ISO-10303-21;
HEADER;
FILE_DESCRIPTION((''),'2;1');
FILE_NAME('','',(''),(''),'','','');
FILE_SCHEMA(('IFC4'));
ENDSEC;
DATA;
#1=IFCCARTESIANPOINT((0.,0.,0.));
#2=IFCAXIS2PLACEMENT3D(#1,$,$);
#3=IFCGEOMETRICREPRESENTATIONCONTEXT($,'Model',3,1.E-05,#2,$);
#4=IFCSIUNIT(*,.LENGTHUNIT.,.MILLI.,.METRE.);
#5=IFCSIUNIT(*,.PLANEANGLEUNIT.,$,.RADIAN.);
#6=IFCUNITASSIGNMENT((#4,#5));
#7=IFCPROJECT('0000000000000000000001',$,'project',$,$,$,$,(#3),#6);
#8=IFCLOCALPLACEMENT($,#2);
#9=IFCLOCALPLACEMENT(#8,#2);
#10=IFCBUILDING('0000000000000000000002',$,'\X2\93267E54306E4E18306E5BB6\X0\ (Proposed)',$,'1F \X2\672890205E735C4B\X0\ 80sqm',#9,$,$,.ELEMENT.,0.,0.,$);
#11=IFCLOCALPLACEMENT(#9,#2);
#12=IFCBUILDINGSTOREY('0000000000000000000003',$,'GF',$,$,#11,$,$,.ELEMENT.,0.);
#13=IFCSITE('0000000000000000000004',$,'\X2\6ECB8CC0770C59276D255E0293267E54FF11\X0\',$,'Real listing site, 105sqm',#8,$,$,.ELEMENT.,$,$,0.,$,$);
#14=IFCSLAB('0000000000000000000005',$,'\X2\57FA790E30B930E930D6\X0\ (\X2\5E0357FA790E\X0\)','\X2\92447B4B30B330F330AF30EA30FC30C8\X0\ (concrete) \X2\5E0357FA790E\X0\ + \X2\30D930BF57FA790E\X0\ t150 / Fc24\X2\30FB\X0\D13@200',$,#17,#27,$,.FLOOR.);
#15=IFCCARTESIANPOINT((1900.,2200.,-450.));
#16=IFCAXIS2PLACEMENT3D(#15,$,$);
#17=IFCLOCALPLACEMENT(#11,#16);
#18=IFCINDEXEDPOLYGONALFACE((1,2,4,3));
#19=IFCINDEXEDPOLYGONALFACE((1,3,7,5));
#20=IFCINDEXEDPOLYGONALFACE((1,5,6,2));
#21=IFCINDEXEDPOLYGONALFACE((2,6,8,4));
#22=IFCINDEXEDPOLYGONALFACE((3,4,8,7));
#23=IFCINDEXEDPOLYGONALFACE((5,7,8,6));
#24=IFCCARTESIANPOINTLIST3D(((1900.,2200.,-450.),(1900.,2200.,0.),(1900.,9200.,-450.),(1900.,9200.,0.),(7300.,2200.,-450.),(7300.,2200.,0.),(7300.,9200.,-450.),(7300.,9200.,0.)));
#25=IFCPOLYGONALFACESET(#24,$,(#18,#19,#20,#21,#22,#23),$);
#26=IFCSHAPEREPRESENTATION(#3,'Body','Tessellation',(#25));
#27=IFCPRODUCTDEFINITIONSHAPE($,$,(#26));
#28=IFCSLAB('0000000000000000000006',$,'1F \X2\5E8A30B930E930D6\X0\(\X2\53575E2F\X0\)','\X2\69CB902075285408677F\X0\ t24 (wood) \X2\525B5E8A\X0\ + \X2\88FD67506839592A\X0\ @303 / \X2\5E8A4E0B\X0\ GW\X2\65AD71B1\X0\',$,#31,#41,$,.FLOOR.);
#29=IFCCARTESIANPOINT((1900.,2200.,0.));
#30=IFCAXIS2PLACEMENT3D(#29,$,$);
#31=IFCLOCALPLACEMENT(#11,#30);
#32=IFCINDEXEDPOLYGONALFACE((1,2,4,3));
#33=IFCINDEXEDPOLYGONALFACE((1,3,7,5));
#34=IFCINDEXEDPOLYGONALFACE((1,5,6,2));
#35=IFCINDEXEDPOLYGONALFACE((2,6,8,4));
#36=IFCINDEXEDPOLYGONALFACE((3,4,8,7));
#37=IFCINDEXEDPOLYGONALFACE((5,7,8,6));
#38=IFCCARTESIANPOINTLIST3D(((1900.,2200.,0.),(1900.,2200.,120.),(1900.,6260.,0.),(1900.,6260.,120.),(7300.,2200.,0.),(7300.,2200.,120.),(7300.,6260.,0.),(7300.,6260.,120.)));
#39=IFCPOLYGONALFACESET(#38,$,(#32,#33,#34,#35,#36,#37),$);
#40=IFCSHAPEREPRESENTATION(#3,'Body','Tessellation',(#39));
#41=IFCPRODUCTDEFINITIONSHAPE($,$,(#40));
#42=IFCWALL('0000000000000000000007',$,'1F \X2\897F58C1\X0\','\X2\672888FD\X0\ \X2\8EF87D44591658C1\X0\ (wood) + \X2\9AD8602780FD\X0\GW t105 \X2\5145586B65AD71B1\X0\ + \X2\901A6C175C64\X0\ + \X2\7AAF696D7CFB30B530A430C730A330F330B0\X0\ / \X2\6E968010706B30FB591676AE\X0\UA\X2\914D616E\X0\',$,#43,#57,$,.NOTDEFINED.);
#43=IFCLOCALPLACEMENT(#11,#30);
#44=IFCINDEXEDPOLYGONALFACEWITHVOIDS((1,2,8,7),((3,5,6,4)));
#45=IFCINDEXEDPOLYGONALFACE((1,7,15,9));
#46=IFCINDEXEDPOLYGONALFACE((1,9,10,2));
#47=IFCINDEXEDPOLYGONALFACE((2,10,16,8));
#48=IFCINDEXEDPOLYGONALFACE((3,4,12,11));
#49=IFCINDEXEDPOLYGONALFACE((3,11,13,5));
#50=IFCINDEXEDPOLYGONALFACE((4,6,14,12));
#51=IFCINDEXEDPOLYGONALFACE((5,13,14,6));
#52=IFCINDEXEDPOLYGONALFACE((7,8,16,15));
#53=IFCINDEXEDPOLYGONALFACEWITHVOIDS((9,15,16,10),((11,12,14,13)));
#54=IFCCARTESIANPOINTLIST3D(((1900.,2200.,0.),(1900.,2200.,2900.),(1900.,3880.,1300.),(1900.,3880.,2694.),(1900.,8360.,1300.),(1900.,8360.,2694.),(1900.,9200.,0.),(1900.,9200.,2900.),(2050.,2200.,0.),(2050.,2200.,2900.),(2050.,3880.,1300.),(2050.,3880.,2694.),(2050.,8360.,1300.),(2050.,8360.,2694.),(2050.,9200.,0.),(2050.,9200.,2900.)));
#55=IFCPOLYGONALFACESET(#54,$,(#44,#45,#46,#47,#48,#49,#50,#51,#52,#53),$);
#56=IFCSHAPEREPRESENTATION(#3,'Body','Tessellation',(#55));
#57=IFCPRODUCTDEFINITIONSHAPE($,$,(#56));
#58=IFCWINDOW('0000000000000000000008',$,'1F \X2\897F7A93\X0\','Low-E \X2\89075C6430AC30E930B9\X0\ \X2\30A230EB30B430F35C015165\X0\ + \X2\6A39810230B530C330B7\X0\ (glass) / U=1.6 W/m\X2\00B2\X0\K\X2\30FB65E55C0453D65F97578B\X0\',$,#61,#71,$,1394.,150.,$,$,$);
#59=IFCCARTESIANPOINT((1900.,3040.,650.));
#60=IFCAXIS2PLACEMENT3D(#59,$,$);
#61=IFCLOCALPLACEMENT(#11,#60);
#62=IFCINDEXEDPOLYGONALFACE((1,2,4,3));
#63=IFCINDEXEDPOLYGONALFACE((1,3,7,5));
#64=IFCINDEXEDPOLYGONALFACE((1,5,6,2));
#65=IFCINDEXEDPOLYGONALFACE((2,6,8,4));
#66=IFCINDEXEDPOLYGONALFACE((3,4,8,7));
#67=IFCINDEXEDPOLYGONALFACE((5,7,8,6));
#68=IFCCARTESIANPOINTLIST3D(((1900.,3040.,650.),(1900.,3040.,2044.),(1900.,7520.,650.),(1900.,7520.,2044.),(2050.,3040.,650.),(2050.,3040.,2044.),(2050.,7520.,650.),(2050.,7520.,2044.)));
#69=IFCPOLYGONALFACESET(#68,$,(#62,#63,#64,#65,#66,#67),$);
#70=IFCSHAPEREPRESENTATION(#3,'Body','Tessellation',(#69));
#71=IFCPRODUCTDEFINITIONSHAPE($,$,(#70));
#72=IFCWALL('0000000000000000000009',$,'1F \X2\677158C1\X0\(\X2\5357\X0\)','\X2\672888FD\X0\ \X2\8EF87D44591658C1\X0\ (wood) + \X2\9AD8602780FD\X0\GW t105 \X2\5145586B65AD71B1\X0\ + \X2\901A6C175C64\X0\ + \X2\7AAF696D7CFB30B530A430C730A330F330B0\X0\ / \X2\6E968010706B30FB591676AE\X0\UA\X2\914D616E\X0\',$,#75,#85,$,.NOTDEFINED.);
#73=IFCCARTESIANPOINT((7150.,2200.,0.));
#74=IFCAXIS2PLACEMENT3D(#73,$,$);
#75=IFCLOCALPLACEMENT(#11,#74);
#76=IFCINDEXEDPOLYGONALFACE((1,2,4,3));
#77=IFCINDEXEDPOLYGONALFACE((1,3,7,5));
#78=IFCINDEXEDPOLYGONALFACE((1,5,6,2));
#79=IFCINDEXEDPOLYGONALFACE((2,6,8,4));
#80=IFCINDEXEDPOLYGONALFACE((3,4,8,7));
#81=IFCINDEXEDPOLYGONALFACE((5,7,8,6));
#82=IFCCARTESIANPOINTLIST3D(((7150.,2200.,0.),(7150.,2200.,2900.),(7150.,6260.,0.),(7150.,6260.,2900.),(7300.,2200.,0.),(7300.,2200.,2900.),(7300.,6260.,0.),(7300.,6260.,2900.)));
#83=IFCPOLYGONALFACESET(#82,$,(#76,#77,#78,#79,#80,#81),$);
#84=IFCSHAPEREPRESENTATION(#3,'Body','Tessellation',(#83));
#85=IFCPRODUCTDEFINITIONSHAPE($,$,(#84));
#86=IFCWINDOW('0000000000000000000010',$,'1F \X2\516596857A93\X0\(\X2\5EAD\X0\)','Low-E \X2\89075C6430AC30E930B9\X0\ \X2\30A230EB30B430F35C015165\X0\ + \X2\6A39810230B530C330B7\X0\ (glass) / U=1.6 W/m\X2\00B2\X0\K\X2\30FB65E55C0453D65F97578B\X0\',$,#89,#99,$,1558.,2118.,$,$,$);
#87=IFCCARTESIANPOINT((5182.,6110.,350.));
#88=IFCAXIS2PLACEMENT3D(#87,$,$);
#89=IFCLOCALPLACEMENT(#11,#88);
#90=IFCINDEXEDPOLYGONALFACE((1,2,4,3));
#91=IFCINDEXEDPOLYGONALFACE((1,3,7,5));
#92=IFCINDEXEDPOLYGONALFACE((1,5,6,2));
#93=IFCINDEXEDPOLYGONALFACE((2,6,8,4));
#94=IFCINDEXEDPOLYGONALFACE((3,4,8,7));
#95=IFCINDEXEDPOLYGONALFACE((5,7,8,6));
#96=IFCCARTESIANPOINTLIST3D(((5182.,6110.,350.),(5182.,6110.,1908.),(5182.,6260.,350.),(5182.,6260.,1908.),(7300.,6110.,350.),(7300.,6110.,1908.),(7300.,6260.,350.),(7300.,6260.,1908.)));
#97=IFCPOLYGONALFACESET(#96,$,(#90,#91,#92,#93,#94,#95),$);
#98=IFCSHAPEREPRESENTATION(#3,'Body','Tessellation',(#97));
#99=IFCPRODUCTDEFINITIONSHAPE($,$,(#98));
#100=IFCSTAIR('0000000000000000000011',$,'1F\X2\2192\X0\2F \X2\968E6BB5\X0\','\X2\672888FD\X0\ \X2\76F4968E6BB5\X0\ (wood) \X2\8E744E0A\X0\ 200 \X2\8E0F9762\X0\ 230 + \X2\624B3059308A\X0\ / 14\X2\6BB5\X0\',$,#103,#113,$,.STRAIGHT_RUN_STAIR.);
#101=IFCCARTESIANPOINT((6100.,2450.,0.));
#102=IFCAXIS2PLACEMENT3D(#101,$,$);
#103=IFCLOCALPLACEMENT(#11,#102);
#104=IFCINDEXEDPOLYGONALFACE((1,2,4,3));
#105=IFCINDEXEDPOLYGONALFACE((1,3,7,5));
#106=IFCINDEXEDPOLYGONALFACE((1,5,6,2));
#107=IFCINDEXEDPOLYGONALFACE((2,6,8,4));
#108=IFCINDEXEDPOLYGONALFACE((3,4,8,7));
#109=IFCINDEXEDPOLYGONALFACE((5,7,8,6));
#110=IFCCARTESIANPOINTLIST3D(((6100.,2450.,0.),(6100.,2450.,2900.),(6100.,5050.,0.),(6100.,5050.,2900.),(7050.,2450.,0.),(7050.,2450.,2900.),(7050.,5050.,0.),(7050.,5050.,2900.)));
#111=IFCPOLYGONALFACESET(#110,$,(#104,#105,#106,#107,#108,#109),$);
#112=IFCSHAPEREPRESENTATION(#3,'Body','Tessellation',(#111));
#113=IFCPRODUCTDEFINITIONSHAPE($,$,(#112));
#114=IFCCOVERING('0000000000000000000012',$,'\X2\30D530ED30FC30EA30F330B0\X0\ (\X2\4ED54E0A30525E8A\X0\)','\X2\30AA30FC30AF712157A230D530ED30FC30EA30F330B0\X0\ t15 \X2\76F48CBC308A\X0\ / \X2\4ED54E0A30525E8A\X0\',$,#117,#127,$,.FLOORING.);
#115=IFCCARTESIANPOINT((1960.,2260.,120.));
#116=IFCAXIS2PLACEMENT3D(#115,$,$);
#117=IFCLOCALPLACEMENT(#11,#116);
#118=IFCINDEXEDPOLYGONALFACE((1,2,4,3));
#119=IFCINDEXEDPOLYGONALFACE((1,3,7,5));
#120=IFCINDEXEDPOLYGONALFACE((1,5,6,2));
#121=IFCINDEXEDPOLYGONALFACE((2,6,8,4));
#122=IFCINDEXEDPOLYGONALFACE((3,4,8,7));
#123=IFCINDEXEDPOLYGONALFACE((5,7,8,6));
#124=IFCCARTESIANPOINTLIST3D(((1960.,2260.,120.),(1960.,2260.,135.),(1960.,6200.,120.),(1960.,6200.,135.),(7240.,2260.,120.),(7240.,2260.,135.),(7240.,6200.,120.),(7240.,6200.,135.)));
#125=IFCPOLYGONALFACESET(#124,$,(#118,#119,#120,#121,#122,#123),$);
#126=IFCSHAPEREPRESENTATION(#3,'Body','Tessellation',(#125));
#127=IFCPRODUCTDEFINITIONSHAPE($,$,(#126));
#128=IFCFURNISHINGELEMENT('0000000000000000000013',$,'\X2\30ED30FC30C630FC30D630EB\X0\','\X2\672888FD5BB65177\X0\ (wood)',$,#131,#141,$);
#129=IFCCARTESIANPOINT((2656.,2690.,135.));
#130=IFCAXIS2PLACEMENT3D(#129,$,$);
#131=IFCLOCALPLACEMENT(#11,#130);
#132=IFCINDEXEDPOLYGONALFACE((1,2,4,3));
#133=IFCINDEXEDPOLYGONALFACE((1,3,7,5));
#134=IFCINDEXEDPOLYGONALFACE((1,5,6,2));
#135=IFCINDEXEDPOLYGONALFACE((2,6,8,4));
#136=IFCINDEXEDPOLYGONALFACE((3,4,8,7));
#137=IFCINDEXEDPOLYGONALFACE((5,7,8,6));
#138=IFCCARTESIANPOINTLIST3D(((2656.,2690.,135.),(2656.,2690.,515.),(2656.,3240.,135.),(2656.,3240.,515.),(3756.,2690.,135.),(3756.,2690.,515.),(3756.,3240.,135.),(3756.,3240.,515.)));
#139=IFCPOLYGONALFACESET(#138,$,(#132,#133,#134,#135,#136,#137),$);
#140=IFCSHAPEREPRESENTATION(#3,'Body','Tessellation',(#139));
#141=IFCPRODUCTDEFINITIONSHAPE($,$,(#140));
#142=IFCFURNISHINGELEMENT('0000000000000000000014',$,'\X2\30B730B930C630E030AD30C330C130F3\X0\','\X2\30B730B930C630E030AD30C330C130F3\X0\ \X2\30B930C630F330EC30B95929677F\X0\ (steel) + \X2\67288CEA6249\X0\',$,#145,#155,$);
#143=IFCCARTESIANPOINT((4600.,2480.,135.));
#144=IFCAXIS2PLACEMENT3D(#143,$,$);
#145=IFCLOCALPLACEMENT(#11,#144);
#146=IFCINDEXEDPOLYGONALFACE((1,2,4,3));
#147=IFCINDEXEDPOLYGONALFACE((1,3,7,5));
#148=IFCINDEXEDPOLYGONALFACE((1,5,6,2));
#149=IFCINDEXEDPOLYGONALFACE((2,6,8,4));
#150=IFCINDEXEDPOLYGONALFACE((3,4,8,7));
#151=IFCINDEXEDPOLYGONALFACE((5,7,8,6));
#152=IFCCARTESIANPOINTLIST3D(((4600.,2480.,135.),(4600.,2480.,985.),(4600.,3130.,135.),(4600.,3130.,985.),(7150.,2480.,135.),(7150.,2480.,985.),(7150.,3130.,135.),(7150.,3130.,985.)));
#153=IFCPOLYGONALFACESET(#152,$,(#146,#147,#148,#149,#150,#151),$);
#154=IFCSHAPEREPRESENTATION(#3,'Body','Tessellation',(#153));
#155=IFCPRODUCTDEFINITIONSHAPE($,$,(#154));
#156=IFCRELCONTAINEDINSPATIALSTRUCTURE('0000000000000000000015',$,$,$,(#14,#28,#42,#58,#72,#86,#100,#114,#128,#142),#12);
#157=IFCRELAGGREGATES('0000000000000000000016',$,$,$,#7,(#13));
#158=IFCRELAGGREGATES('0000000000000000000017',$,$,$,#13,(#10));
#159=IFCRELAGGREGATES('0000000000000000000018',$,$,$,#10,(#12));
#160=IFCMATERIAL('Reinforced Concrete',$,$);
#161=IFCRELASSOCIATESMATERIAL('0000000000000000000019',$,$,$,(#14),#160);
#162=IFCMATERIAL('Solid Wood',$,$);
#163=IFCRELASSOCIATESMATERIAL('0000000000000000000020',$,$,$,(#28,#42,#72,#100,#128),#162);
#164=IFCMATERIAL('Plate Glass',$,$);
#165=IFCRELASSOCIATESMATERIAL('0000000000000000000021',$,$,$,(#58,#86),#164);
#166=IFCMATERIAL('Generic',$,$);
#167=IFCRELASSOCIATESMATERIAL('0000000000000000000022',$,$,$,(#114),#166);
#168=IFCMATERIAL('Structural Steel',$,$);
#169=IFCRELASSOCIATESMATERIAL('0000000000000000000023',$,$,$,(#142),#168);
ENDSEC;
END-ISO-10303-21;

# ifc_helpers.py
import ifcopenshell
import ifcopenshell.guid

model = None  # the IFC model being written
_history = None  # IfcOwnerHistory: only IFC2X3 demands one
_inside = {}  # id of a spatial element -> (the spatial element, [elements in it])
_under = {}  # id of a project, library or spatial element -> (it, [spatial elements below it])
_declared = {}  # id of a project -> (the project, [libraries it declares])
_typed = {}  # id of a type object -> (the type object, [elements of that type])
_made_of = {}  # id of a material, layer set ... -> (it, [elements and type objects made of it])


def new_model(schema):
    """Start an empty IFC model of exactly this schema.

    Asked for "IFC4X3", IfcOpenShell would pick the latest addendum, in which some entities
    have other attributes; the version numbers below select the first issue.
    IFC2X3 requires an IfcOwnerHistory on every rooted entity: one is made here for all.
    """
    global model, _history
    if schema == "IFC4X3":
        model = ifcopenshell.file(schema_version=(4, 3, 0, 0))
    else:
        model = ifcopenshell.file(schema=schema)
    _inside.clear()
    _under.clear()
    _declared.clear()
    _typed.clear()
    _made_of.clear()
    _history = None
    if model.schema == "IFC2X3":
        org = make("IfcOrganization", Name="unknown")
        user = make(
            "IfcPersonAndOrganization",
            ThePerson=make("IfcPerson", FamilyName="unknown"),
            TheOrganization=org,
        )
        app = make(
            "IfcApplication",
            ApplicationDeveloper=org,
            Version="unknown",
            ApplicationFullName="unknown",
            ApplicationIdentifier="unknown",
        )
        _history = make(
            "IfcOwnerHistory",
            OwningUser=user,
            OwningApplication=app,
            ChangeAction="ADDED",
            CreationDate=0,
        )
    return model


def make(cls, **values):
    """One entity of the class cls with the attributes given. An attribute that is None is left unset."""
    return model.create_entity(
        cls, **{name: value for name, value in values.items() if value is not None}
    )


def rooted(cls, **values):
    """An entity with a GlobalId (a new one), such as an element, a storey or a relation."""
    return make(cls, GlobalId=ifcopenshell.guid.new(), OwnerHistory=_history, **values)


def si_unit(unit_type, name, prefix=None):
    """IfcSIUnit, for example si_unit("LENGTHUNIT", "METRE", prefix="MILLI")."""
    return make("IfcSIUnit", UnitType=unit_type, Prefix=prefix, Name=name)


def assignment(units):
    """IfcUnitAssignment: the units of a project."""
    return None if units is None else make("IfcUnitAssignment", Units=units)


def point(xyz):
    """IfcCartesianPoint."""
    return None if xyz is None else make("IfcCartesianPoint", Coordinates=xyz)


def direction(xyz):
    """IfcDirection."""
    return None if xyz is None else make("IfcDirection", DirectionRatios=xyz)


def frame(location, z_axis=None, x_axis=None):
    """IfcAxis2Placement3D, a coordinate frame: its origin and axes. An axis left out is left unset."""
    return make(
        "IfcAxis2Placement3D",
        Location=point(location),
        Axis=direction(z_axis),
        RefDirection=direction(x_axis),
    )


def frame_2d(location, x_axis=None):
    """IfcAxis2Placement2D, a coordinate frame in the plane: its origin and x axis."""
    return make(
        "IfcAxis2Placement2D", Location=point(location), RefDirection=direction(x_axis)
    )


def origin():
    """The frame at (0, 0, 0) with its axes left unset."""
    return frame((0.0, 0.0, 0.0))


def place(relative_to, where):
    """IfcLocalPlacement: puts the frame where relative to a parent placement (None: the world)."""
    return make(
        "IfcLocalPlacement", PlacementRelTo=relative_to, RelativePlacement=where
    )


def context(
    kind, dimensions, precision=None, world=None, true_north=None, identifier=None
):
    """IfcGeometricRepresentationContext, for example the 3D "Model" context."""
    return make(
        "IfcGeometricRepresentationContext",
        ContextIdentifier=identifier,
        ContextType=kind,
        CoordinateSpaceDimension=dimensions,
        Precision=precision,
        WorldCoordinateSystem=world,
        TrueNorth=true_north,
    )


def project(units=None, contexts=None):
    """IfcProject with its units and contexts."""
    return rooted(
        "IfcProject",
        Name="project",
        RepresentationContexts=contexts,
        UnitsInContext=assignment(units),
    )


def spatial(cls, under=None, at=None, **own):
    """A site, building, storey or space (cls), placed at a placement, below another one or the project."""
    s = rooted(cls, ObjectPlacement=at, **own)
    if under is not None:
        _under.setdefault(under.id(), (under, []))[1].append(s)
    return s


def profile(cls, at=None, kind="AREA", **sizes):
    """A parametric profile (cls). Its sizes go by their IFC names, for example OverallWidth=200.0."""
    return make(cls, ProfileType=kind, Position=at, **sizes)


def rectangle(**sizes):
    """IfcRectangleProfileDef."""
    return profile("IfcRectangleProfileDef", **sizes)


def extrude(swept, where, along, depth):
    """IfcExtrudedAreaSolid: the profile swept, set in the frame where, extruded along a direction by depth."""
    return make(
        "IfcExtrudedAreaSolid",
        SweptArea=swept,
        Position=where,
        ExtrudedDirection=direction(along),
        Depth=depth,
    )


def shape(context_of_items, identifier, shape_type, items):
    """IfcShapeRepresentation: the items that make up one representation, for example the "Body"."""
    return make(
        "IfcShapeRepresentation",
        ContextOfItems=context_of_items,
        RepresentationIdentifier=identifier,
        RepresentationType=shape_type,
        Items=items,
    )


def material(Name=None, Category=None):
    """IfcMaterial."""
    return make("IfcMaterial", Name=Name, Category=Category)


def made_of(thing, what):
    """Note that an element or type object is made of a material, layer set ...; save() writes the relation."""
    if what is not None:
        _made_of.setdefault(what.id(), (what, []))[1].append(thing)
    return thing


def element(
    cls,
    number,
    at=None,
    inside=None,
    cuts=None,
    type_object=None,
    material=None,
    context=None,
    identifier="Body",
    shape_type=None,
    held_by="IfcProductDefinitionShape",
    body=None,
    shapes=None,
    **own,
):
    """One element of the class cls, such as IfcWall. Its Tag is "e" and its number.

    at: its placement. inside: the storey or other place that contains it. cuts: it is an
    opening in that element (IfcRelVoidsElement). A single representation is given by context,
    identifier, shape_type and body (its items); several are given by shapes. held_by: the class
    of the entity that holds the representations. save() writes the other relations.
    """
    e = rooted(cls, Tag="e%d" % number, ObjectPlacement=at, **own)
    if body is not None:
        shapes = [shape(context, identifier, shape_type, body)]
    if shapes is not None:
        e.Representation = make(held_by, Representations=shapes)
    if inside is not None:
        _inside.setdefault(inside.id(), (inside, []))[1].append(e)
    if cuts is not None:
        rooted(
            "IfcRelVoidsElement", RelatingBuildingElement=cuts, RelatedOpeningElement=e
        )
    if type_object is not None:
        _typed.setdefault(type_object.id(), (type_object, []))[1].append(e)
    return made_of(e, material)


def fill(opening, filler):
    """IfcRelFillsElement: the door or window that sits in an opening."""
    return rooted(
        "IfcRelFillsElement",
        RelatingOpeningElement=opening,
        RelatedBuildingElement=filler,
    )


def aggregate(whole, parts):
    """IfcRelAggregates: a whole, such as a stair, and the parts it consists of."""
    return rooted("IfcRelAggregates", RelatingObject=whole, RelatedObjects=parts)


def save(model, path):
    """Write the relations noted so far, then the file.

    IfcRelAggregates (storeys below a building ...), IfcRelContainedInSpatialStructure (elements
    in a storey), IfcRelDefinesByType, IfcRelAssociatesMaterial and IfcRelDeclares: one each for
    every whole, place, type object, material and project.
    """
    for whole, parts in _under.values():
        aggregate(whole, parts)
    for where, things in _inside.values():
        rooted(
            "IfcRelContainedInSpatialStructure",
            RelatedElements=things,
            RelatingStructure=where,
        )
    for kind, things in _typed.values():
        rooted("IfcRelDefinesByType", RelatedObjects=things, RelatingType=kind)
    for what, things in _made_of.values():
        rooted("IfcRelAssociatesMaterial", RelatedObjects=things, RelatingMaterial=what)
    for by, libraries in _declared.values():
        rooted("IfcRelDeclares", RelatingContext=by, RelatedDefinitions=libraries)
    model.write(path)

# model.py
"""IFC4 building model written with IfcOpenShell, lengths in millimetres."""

from ifc_helpers import new_model, si_unit, frame, frame_2d, origin, place, context, project, spatial, rectangle, extrude, material, element, fill, save


model = new_model("IFC4")

# Units and contexts
model_context = context("Model", 3, precision=1e-05, world=origin())
ifc_project = project(units=[si_unit("LENGTHUNIT", "METRE", prefix="MILLI"), si_unit("PLANEANGLEUNIT", "RADIAN")], contexts=[model_context])

# Site, building, storey
site_placement = place(None, origin())
site = spatial("IfcSite", under=ifc_project, at=site_placement, Name="滋賀県大津市錦織１", ObjectType="Real listing site, 105sqm", CompositionType="ELEMENT", RefElevation=0.0)
building_placement = place(site_placement, origin())
building = spatial("IfcBuilding", under=site, at=building_placement, Name="錦織の丘の家 (Proposed)", ObjectType="1F 木造平屋 80sqm", CompositionType="ELEMENT", ElevationOfRefHeight=0.0, ElevationOfTerrain=0.0)
storey_placement = place(building_placement, origin())
storey = spatial("IfcBuildingStorey", under=building, at=storey_placement, Name="GF", CompositionType="ELEMENT", Elevation=0.0)

# Slabs
ifc_material_1 = material(Name="Reinforced Concrete")
slab_1_placement = place(storey_placement, frame((1900.0, 2200.0, -450.0)))
element("IfcSlab", 1, at=slab_1_placement, inside=storey, material=ifc_material_1, Name="基礎スラブ (布基礎)", Description="鉄筋コンクリート (concrete) 布基礎 + ベタ基礎 t150 / Fc24・D13@200", PredefinedType="FLOOR", context=model_context, shape_type="SweptSolid", body=[
    extrude(rectangle(XDim=5400.0, YDim=7000.0, at=frame_2d((2700.0, 3500.0))), frame((1900.0, 2200.0, -450.0)), (0.0, 0.0, 1.0), 450.0),
])
ifc_material_2 = material(Name="Solid Wood")
slab_2_placement = place(storey_placement, frame((1900.0, 2200.0, 0.0)))
element("IfcSlab", 2, at=slab_2_placement, inside=storey, material=ifc_material_2, Name="1F 床スラブ(南帯)", Description="構造用合板 t24 (wood) 剛床 + 製材根太 @303 / 床下 GW断熱", PredefinedType="FLOOR", context=model_context, shape_type="SweptSolid", body=[
    extrude(rectangle(XDim=5400.0, YDim=4060.0, at=frame_2d((2700.0, 2030.0))), frame((1900.0, 2200.0, 0.0)), (0.0, 0.0, 1.0), 120.0),
])

# Shared definitions
ifc_material_3 = material(Name="Plate Glass")
ifc_material_4 = material(Name="Generic")

# Walls, openings, windows
wall_1_placement = place(storey_placement, frame((1900.0, 2200.0, 0.0)))
wall_1 = element("IfcWall", 3, at=wall_1_placement, inside=storey, material=ifc_material_2, Name="1F 西壁", Description="木製 軸組外壁 (wood) + 高性能GW t105 充填断熱 + 通気層 + 窯業系サイディング / 準耐火・外皮UA配慮", PredefinedType="NOTDEFINED", context=model_context, shape_type="SweptSolid", body=[
    extrude(rectangle(XDim=150.0, YDim=7000.0, at=frame_2d((75.0, 3500.0))), frame((1900.0, 2200.0, 0.0)), (0.0, 0.0, 1.0), 2900.0),
])
opening_1_placement = place(storey_placement, frame((1900.0, 3040.0, 650.0)))
opening_1 = element("IfcOpeningElement", 4, at=opening_1_placement, cuts=wall_1, PredefinedType="NOTDEFINED", context=model_context, shape_type="SweptSolid", body=[
    extrude(rectangle(XDim=150.0, YDim=4480.0, at=frame_2d((75.0, 2240.0))), frame((1900.0, 3040.0, 650.0)), (0.0, 0.0, 1.0), 1394.0),
])
window_1_placement = place(storey_placement, frame((1900.0, 3040.0, 650.0)))
window_1 = element("IfcWindow", 5, at=window_1_placement, inside=storey, material=ifc_material_3, Name="1F 西窓", Description="Low-E 複層ガラス アルゴン封入 + 樹脂サッシ (glass) / U=1.6 W/m²K・日射取得型", OverallHeight=1394.0, OverallWidth=150.0, context=model_context, shape_type="SweptSolid", body=[
    extrude(rectangle(XDim=150.0, YDim=4480.0, at=frame_2d((75.0, 2240.0))), frame((1900.0, 3040.0, 650.0)), (0.0, 0.0, 1.0), 1394.0),
])
fill(opening_1, window_1)
wall_2_placement = place(storey_placement, frame((7150.0, 2200.0, 0.0)))
wall_2 = element("IfcWall", 6, at=wall_2_placement, inside=storey, material=ifc_material_2, Name="1F 東壁(南)", Description="木製 軸組外壁 (wood) + 高性能GW t105 充填断熱 + 通気層 + 窯業系サイディング / 準耐火・外皮UA配慮", PredefinedType="NOTDEFINED", context=model_context, shape_type="SweptSolid", body=[
    extrude(rectangle(XDim=150.0, YDim=4060.0, at=frame_2d((75.0, 2030.0))), frame((7150.0, 2200.0, 0.0)), (0.0, 0.0, 1.0), 2900.0),
])
opening_2_placement = place(storey_placement, frame((5182.0, 6110.0, 350.0)))
opening_2 = element("IfcOpeningElement", 7, at=opening_2_placement, cuts=wall_2, PredefinedType="NOTDEFINED", context=model_context, shape_type="SweptSolid", body=[
    extrude(rectangle(XDim=2118.0, YDim=150.0, at=frame_2d((1059.0, 75.0))), frame((5182.0, 6110.0, 350.0)), (0.0, 0.0, 1.0), 1558.0),
])
window_2_placement = place(storey_placement, frame((5182.0, 6110.0, 350.0)))
window_2 = element("IfcWindow", 8, at=window_2_placement, inside=storey, material=ifc_material_3, Name="1F 入隅窓(庭)", Description="Low-E 複層ガラス アルゴン封入 + 樹脂サッシ (glass) / U=1.6 W/m²K・日射取得型", OverallHeight=1558.0, OverallWidth=2118.0, context=model_context, shape_type="SweptSolid", body=[
    extrude(rectangle(XDim=2118.0, YDim=150.0, at=frame_2d((1059.0, 75.0))), frame((5182.0, 6110.0, 350.0)), (0.0, 0.0, 1.0), 1558.0),
])
fill(opening_2, window_2)

# Stair
stair_placement = place(storey_placement, frame((6100.0, 2450.0, 0.0)))
element("IfcStair", 9, at=stair_placement, inside=storey, material=ifc_material_2, Name="1F→2F 階段", Description="木製 直階段 (wood) 蹴上 200 踏面 230 + 手すり / 14段", PredefinedType="STRAIGHT_RUN_STAIR", context=model_context, shape_type="SweptSolid", body=[
    extrude(rectangle(XDim=950.0, YDim=2600.0, at=frame_2d((475.0, 1300.0))), frame((6100.0, 2450.0, 0.0)), (0.0, 0.0, 1.0), 2900.0),
])

# Covering
covering_placement = place(storey_placement, frame((1960.0, 2260.0, 120.0)))
element("IfcCovering", 10, at=covering_placement, inside=storey, material=ifc_material_4, Name="フローリング (仕上げ床)", Description="オーク無垢フローリング t15 直貼り / 仕上げ床", PredefinedType="FLOORING", context=model_context, shape_type="SweptSolid", body=[
    extrude(rectangle(XDim=5280.0, YDim=3940.0, at=frame_2d((2640.0, 1970.0))), frame((1960.0, 2260.0, 120.0)), (0.0, 0.0, 1.0), 15.0),
])

# Furnishing elements
furnishing_1_placement = place(storey_placement, frame((2656.0, 2690.0, 135.0)))
element("IfcFurnishingElement", 11, at=furnishing_1_placement, inside=storey, material=ifc_material_2, Name="ローテーブル", Description="木製家具 (wood)", context=model_context, shape_type="SweptSolid", body=[
    extrude(rectangle(XDim=1100.0, YDim=550.0, at=frame_2d((550.0, 275.0))), frame((2656.0, 2690.0, 135.0)), (0.0, 0.0, 1.0), 380.0),
])
ifc_material_5 = material(Name="Structural Steel")
furnishing_2_placement = place(storey_placement, frame((4600.0, 2480.0, 135.0)))
element("IfcFurnishingElement", 12, at=furnishing_2_placement, inside=storey, material=ifc_material_5, Name="システムキッチン", Description="システムキッチン ステンレス天板 (steel) + 木質扉", context=model_context, shape_type="SweptSolid", body=[
    extrude(rectangle(XDim=2550.0, YDim=650.0, at=frame_2d((1275.0, 325.0))), frame((4600.0, 2480.0, 135.0)), (0.0, 0.0, 1.0), 850.0),
])

save(model, "model.ifc")
